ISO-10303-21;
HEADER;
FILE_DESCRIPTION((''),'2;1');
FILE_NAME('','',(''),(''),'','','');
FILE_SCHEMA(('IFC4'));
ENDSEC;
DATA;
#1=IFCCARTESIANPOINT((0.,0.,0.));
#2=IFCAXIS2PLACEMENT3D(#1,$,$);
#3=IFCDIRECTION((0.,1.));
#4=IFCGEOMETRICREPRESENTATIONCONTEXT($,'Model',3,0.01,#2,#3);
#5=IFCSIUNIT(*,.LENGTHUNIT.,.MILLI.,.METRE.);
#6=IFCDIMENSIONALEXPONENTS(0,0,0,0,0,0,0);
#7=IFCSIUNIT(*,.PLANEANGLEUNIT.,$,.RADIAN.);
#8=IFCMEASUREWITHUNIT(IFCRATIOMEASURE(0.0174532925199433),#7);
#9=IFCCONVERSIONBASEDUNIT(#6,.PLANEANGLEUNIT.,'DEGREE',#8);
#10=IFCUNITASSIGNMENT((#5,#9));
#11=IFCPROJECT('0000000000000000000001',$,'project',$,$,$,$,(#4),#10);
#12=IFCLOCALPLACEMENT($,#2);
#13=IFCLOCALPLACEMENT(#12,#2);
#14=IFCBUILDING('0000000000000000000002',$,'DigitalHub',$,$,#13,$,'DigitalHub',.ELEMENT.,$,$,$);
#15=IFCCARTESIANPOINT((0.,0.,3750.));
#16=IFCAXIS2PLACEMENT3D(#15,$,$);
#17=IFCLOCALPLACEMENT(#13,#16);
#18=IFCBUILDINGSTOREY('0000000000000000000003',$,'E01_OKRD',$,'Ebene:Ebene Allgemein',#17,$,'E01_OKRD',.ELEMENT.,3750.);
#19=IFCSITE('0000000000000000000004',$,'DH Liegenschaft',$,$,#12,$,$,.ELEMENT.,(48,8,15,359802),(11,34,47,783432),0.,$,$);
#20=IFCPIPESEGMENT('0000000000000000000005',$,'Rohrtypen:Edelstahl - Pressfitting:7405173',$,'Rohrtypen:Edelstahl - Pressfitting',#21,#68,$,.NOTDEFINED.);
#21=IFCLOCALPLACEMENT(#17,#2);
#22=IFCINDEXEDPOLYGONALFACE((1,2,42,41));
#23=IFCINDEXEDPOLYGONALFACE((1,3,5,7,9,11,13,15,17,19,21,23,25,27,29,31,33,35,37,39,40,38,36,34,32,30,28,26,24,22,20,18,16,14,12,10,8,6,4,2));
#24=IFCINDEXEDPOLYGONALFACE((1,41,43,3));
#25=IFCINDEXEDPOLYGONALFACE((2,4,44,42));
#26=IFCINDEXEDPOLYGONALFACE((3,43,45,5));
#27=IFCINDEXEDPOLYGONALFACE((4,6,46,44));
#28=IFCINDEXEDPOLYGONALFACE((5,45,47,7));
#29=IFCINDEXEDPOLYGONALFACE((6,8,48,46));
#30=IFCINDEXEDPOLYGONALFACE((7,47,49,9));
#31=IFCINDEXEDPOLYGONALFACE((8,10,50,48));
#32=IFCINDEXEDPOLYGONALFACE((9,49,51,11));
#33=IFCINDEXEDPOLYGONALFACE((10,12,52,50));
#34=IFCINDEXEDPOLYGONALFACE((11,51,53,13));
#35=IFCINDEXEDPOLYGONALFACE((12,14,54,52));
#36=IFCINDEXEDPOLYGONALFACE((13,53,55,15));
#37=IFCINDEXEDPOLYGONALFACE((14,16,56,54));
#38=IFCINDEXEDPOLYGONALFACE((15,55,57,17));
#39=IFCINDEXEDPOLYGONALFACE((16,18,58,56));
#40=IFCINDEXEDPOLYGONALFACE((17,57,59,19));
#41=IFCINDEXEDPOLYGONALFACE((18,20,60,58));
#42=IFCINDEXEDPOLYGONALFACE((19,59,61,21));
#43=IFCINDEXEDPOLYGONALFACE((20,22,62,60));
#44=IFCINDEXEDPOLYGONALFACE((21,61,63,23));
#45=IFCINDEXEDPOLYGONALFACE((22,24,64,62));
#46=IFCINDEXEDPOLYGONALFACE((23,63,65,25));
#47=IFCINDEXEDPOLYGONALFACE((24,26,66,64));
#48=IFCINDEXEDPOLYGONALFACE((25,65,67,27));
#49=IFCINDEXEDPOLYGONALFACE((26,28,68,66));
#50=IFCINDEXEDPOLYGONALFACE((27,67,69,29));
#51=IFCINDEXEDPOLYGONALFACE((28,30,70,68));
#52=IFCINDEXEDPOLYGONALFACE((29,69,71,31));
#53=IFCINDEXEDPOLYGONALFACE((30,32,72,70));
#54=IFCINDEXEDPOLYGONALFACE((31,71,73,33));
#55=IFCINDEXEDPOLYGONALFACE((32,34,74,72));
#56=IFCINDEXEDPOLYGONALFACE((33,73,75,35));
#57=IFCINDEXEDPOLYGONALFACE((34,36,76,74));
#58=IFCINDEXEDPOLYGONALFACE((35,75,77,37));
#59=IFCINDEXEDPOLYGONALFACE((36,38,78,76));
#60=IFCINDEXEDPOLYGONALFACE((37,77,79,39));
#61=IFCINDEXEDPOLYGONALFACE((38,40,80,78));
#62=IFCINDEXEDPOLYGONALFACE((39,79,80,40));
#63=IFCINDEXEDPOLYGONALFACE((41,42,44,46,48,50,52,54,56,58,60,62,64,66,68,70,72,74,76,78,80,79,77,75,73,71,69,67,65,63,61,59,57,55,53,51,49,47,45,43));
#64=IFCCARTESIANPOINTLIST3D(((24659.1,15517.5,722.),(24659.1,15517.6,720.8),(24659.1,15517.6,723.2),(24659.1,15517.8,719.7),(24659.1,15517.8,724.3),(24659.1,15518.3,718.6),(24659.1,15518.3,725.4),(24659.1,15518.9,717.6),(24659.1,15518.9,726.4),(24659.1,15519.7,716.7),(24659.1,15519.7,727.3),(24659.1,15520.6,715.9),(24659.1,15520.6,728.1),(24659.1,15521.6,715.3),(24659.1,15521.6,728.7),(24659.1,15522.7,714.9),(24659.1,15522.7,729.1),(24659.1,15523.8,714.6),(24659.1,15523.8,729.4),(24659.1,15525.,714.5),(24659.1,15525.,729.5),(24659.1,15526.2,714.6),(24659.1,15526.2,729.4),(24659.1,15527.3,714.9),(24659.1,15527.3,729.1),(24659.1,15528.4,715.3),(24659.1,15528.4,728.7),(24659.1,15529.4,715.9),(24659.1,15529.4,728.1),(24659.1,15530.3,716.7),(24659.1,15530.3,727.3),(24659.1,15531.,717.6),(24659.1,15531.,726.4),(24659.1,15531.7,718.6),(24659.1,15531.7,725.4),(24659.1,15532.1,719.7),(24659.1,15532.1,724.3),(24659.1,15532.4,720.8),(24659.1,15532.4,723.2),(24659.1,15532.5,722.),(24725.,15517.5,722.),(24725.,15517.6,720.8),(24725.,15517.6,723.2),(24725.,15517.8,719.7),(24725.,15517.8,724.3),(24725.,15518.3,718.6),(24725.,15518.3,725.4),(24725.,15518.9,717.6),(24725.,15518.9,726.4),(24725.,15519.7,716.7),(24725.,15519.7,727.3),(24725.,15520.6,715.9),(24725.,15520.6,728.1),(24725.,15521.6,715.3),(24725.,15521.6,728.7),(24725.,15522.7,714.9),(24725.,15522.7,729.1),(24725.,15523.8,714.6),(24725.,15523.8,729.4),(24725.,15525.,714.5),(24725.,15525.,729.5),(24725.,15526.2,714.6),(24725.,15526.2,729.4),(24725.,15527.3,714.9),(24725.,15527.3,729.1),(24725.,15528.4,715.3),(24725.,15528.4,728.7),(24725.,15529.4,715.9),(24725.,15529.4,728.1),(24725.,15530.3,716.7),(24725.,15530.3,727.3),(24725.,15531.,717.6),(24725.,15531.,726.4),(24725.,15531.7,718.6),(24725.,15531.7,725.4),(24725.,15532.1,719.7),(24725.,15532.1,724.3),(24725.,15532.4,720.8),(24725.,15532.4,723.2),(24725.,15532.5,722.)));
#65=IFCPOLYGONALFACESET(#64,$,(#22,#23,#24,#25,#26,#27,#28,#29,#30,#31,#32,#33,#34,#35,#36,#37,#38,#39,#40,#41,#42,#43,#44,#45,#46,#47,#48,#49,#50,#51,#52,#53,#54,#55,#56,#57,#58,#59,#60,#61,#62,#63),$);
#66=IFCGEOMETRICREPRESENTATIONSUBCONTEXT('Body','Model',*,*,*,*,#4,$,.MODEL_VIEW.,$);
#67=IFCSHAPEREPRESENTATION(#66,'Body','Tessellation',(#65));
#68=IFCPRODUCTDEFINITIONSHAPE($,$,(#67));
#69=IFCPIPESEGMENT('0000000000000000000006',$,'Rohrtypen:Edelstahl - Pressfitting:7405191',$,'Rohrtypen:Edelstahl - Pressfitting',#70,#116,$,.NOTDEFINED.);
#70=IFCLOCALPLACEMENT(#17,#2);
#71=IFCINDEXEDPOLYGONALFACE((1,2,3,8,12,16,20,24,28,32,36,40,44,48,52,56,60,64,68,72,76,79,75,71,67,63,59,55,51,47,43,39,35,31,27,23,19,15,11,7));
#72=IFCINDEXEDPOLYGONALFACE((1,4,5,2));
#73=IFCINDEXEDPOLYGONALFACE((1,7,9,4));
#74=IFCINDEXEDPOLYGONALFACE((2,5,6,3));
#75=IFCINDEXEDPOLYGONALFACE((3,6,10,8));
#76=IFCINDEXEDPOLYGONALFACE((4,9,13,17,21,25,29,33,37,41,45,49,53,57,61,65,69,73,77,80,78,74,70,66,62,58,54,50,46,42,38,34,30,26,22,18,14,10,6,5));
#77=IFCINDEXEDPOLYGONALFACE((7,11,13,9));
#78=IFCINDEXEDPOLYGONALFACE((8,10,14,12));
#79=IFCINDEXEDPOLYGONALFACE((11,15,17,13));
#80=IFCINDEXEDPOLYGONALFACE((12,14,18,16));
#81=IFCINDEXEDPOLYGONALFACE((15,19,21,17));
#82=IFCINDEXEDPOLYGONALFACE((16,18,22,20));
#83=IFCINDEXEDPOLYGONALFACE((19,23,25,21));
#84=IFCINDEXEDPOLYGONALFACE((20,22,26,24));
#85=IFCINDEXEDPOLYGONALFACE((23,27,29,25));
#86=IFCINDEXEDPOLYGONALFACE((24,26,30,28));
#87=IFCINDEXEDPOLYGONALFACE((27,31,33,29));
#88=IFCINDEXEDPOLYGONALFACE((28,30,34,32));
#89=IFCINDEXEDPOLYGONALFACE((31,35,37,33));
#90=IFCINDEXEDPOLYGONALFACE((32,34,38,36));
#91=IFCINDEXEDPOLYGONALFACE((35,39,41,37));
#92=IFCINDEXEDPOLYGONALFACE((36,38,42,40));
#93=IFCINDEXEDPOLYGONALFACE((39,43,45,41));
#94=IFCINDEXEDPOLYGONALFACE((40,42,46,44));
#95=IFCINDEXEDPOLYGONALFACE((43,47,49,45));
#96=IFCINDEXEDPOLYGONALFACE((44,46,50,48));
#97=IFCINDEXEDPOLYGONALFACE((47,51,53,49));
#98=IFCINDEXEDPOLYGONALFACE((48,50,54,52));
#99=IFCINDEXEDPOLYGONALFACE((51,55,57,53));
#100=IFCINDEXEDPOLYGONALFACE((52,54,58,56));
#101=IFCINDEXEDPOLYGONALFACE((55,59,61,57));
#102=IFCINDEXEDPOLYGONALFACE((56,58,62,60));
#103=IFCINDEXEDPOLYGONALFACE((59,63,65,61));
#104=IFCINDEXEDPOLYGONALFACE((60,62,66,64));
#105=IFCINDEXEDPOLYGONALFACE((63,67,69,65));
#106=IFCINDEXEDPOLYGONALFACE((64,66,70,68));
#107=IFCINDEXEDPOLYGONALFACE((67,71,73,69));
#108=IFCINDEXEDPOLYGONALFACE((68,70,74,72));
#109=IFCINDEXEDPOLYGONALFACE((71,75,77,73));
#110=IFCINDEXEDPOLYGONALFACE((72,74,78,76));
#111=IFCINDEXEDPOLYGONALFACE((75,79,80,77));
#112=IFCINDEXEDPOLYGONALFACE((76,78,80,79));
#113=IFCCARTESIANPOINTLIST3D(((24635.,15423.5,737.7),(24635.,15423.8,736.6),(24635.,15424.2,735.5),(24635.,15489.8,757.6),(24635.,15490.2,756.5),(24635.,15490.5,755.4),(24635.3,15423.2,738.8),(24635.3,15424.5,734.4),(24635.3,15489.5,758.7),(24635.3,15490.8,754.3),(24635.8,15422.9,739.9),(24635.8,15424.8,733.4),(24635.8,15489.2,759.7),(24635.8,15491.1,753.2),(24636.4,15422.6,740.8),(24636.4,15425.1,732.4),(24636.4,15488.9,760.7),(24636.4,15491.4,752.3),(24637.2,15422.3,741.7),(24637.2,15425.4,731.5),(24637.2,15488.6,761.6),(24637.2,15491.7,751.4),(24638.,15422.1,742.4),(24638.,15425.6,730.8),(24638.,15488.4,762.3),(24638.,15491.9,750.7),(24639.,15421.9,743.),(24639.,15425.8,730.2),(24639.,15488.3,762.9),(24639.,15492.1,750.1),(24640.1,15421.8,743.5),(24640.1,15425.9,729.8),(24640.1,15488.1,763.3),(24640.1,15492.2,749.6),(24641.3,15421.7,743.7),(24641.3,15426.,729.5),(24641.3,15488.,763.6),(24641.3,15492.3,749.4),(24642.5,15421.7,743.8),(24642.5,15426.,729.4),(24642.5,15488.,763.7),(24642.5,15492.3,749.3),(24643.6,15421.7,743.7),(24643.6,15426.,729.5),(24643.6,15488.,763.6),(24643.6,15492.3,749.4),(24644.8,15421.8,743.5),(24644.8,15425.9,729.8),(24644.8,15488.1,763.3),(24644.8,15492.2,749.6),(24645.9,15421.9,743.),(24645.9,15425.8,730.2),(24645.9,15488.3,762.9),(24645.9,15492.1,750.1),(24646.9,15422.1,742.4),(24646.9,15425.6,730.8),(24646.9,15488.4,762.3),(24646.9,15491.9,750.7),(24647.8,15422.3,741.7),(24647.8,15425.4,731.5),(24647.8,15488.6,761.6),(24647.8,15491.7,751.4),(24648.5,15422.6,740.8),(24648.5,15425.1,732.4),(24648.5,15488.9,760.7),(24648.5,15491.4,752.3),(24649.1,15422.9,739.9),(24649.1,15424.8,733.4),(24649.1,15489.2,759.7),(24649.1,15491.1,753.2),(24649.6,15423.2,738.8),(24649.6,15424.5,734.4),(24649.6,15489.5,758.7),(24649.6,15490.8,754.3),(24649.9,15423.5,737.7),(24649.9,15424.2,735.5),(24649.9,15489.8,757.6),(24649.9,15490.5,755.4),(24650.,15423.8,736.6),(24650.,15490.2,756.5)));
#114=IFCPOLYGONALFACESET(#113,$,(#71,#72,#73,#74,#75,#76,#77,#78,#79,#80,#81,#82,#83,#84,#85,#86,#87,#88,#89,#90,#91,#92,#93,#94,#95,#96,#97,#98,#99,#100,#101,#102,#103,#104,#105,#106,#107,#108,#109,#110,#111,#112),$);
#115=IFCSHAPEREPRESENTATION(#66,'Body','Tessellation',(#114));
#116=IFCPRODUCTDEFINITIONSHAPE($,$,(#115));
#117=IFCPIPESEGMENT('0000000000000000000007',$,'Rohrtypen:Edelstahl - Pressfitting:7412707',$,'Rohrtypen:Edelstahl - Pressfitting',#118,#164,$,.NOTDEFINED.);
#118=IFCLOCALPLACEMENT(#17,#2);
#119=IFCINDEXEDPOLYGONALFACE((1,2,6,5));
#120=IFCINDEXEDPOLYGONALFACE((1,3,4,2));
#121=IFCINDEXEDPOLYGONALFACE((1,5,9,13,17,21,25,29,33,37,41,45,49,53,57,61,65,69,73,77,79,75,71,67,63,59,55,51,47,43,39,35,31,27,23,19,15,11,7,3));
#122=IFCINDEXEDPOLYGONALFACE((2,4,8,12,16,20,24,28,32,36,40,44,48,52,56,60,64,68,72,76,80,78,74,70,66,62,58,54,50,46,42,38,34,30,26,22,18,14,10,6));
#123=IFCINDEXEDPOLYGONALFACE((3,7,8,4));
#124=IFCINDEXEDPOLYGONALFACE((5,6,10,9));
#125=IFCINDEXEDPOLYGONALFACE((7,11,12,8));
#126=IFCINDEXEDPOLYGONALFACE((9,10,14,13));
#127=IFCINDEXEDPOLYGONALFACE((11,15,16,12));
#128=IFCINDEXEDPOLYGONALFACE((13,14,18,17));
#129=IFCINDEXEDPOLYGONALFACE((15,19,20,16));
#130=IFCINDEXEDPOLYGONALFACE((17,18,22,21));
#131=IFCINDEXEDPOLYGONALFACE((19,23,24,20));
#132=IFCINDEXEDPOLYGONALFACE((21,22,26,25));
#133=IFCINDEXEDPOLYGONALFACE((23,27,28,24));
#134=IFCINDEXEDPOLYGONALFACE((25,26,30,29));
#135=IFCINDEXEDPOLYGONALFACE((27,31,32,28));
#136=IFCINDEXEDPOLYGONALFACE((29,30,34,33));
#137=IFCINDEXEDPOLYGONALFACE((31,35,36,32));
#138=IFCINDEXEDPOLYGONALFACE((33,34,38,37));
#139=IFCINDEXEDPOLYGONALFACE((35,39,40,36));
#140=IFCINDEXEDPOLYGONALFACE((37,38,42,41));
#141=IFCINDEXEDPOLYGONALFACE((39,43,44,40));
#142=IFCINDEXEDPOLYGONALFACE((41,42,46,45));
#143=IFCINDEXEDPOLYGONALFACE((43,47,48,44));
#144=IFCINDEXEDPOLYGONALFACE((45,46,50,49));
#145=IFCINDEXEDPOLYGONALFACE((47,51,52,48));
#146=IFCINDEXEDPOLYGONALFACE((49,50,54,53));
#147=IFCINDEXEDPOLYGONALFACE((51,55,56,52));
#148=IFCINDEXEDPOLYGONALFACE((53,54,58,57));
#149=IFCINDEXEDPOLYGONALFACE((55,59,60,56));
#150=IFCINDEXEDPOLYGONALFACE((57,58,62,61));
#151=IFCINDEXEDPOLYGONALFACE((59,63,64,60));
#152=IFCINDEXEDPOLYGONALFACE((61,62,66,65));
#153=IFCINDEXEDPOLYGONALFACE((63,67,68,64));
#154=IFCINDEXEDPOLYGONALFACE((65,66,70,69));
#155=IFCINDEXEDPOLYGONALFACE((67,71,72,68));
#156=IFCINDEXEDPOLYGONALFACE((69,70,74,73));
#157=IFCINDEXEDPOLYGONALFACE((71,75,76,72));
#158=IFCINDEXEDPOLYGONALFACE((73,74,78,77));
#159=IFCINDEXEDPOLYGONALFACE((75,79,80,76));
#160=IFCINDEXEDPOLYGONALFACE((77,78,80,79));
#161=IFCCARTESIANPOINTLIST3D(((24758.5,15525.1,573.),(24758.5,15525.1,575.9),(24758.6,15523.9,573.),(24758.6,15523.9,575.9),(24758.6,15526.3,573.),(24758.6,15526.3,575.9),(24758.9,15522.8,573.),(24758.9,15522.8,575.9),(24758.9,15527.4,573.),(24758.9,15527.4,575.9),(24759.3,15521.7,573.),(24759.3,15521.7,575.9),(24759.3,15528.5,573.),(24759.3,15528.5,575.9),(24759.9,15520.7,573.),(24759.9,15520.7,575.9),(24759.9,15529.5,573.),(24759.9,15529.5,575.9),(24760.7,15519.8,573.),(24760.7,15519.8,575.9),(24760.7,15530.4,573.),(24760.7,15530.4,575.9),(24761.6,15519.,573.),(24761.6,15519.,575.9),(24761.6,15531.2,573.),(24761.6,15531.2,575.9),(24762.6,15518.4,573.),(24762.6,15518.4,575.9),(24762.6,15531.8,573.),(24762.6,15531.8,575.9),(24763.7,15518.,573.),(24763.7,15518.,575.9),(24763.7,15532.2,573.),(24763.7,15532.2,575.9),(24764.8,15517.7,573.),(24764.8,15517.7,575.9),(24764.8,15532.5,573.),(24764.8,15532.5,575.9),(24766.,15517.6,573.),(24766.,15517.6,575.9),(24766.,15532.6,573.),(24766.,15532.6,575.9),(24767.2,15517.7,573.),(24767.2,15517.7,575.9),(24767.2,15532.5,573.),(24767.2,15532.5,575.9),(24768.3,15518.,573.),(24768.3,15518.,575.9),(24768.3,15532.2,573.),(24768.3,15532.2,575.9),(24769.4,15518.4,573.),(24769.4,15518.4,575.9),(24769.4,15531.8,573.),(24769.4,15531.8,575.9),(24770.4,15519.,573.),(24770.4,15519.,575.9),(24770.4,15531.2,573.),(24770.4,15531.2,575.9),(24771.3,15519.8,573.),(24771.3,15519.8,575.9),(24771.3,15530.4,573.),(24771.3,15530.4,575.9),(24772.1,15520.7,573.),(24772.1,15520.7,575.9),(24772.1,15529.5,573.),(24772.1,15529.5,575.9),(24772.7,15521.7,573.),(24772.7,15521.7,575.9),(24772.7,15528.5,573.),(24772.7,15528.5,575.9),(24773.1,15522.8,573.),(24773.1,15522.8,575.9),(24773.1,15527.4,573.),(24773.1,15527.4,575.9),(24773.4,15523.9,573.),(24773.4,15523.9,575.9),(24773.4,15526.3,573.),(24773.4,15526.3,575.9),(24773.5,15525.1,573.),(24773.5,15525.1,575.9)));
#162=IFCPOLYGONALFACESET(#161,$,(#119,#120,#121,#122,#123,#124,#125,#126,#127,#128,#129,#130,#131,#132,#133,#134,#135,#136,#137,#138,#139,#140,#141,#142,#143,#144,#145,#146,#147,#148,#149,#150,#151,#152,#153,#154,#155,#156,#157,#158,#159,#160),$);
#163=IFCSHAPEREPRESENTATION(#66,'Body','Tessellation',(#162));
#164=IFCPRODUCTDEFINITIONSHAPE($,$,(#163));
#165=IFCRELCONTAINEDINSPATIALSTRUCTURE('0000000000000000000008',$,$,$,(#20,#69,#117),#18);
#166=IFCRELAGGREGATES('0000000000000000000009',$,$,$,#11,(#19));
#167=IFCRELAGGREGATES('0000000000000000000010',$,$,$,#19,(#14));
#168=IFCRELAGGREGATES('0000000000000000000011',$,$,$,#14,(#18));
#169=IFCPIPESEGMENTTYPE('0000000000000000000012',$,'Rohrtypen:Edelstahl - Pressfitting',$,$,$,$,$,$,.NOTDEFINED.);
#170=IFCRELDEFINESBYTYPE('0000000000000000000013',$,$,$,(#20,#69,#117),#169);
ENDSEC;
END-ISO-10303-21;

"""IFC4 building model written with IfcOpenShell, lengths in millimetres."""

from ifc_helpers import new_model, entity, si_unit, converted_unit, direction, frame, origin, place, context, subcontext, project, spatial, indexed_curve, outline, extrude, type_object, element, save


model = new_model("IFC4")

# Units and contexts
model_context = context("Model", 3, precision=0.01, world=origin(), true_north=direction((0.0, 1.0)))
body_context = subcontext(model_context, "Body", "Model", "MODEL_VIEW")
ifc_project = project(units=[si_unit("LENGTHUNIT", "METRE", prefix="MILLI"), converted_unit("PLANEANGLEUNIT", "DEGREE", entity("IfcRatioMeasure", 0.0174532925199433), si_unit("PLANEANGLEUNIT", "RADIAN"), dimensions=[0, 0, 0, 0, 0, 0, 0])], contexts=[model_context])

# Site, building, storey
site_placement = place(None, origin())
site = spatial("IfcSite", under=ifc_project, at=site_placement, Name="DH Liegenschaft", CompositionType="ELEMENT", RefLatitude=(48, 8, 15, 359802), RefLongitude=(11, 34, 47, 783432), RefElevation=0.0)
building_placement = place(site_placement, origin())
building = spatial("IfcBuilding", under=site, at=building_placement, Name="DigitalHub", LongName="DigitalHub", CompositionType="ELEMENT")
storey_placement = place(building_placement, frame((0.0, 0.0, 3750.0)))
storey = spatial("IfcBuildingStorey", under=building, at=storey_placement, Name="E01_OKRD", ObjectType="Ebene:Ebene Allgemein", LongName="E01_OKRD", CompositionType="ELEMENT", Elevation=3750.0)

# Pipe segments
pipe_segment_type_1 = type_object("IfcPipeSegmentType", Name="Rohrtypen:Edelstahl - Pressfitting", PredefinedType="NOTDEFINED")
pipe_segment_1_placement = place(storey_placement, frame((24659.1, 15515.9, 712.9)))
element("IfcPipeSegment", 1, at=pipe_segment_1_placement, inside=storey, type_object=pipe_segment_type_1, Name="Rohrtypen:Edelstahl - Pressfitting:7405173", ObjectType="Rohrtypen:Edelstahl - Pressfitting", PredefinedType="NOTDEFINED", context=body_context, shape_type="SweptSolid", body=[
    extrude(outline(indexed_curve([(7.5, 0.0), (7.4, 1.2), (7.1, 2.3), (6.7, 3.4), (6.1, 4.4), (5.3, 5.3), (4.4, 6.1), (3.4, 6.7), (2.3, 7.1), (1.2, 7.4), (0.0, 7.5), (-1.2, 7.4), (-2.3, 7.1), (-3.4, 6.7), (-4.4, 6.1), (-5.3, 5.3), (-6.1, 4.4), (-6.7, 3.4), (-7.1, 2.3), (-7.4, 1.2), (-7.5, 0.0), (-7.4, -1.2), (-7.1, -2.3), (-6.7, -3.4), (-6.1, -4.4), (-5.3, -5.3), (-4.4, -6.1), (-3.4, -6.7), (-2.3, -7.1), (-1.2, -7.4), (0.0, -7.5), (1.2, -7.4), (2.3, -7.1), (3.4, -6.7), (4.4, -6.1), (5.3, -5.3), (6.1, -4.4), (6.7, -3.4), (7.1, -2.3), (7.4, -1.2), (7.5, 0.0)], self_intersect=False)), frame((0.0, 9.1, 9.1), z_axis=(1.0, 0.0, 0.0), x_axis=(0.0, 1.0, 0.0)), (0.0, 0.0, 1.0), 65.8),
])
pipe_segment_2_placement = place(storey_placement, frame((24633.4, 15420.1, 727.8)))
element("IfcPipeSegment", 2, at=pipe_segment_2_placement, inside=storey, type_object=pipe_segment_type_1, Name="Rohrtypen:Edelstahl - Pressfitting:7405191", ObjectType="Rohrtypen:Edelstahl - Pressfitting", PredefinedType="NOTDEFINED", context=body_context, shape_type="SweptSolid", body=[
    extrude(outline(indexed_curve([(7.5, 0.0), (7.4, 1.2), (7.1, 2.3), (6.7, 3.4), (6.1, 4.4), (5.3, 5.3), (4.4, 6.1), (3.4, 6.7), (2.3, 7.1), (1.2, 7.4), (0.0, 7.5), (-1.2, 7.4), (-2.3, 7.1), (-3.4, 6.7), (-4.4, 6.1), (-5.3, 5.3), (-6.1, 4.4), (-6.7, 3.4), (-7.1, 2.3), (-7.4, 1.2), (-7.5, 0.0), (-7.4, -1.2), (-7.1, -2.3), (-6.7, -3.4), (-6.1, -4.4), (-5.3, -5.3), (-4.4, -6.1), (-3.4, -6.7), (-2.3, -7.1), (-1.2, -7.4), (0.0, -7.5), (1.2, -7.4), (2.3, -7.1), (3.4, -6.7), (4.4, -6.1), (5.3, -5.3), (6.1, -4.4), (6.7, -3.4), (7.1, -2.3), (7.4, -1.2), (7.5, 0.0)], self_intersect=False)), frame((9.1, 3.7, 8.8), z_axis=(0.0, 0.958005, 0.286752), x_axis=(1.0, 0.0, 0.0)), (0.0, 0.0, 1.0), 69.2),
])
pipe_segment_3_placement = place(storey_placement, frame((24756.9, 15516.0, 573.0)))
element("IfcPipeSegment", 3, at=pipe_segment_3_placement, inside=storey, type_object=pipe_segment_type_1, Name="Rohrtypen:Edelstahl - Pressfitting:7412707", ObjectType="Rohrtypen:Edelstahl - Pressfitting", PredefinedType="NOTDEFINED", context=body_context, shape_type="SweptSolid", body=[
    extrude(outline(indexed_curve([(7.5, 0.0), (7.4, 1.2), (7.1, 2.3), (6.7, 3.4), (6.1, 4.4), (5.3, 5.3), (4.4, 6.1), (3.4, 6.7), (2.3, 7.1), (1.2, 7.4), (0.0, 7.5), (-1.2, 7.4), (-2.3, 7.1), (-3.4, 6.7), (-4.4, 6.1), (-5.3, 5.3), (-6.1, 4.4), (-6.7, 3.4), (-7.1, 2.3), (-7.4, 1.2), (-7.5, 0.0), (-7.4, -1.2), (-7.1, -2.3), (-6.7, -3.4), (-6.1, -4.4), (-5.3, -5.3), (-4.4, -6.1), (-3.4, -6.7), (-2.3, -7.1), (-1.2, -7.4), (0.0, -7.5), (1.2, -7.4), (2.3, -7.1), (3.4, -6.7), (4.4, -6.1), (5.3, -5.3), (6.1, -4.4), (6.7, -3.4), (7.1, -2.3), (7.4, -1.2), (7.5, 0.0)], self_intersect=False)), frame((9.1, 9.1, 0.0)), (0.0, 0.0, 1.0), 2.9),
])

save(model, "model.ifc")
